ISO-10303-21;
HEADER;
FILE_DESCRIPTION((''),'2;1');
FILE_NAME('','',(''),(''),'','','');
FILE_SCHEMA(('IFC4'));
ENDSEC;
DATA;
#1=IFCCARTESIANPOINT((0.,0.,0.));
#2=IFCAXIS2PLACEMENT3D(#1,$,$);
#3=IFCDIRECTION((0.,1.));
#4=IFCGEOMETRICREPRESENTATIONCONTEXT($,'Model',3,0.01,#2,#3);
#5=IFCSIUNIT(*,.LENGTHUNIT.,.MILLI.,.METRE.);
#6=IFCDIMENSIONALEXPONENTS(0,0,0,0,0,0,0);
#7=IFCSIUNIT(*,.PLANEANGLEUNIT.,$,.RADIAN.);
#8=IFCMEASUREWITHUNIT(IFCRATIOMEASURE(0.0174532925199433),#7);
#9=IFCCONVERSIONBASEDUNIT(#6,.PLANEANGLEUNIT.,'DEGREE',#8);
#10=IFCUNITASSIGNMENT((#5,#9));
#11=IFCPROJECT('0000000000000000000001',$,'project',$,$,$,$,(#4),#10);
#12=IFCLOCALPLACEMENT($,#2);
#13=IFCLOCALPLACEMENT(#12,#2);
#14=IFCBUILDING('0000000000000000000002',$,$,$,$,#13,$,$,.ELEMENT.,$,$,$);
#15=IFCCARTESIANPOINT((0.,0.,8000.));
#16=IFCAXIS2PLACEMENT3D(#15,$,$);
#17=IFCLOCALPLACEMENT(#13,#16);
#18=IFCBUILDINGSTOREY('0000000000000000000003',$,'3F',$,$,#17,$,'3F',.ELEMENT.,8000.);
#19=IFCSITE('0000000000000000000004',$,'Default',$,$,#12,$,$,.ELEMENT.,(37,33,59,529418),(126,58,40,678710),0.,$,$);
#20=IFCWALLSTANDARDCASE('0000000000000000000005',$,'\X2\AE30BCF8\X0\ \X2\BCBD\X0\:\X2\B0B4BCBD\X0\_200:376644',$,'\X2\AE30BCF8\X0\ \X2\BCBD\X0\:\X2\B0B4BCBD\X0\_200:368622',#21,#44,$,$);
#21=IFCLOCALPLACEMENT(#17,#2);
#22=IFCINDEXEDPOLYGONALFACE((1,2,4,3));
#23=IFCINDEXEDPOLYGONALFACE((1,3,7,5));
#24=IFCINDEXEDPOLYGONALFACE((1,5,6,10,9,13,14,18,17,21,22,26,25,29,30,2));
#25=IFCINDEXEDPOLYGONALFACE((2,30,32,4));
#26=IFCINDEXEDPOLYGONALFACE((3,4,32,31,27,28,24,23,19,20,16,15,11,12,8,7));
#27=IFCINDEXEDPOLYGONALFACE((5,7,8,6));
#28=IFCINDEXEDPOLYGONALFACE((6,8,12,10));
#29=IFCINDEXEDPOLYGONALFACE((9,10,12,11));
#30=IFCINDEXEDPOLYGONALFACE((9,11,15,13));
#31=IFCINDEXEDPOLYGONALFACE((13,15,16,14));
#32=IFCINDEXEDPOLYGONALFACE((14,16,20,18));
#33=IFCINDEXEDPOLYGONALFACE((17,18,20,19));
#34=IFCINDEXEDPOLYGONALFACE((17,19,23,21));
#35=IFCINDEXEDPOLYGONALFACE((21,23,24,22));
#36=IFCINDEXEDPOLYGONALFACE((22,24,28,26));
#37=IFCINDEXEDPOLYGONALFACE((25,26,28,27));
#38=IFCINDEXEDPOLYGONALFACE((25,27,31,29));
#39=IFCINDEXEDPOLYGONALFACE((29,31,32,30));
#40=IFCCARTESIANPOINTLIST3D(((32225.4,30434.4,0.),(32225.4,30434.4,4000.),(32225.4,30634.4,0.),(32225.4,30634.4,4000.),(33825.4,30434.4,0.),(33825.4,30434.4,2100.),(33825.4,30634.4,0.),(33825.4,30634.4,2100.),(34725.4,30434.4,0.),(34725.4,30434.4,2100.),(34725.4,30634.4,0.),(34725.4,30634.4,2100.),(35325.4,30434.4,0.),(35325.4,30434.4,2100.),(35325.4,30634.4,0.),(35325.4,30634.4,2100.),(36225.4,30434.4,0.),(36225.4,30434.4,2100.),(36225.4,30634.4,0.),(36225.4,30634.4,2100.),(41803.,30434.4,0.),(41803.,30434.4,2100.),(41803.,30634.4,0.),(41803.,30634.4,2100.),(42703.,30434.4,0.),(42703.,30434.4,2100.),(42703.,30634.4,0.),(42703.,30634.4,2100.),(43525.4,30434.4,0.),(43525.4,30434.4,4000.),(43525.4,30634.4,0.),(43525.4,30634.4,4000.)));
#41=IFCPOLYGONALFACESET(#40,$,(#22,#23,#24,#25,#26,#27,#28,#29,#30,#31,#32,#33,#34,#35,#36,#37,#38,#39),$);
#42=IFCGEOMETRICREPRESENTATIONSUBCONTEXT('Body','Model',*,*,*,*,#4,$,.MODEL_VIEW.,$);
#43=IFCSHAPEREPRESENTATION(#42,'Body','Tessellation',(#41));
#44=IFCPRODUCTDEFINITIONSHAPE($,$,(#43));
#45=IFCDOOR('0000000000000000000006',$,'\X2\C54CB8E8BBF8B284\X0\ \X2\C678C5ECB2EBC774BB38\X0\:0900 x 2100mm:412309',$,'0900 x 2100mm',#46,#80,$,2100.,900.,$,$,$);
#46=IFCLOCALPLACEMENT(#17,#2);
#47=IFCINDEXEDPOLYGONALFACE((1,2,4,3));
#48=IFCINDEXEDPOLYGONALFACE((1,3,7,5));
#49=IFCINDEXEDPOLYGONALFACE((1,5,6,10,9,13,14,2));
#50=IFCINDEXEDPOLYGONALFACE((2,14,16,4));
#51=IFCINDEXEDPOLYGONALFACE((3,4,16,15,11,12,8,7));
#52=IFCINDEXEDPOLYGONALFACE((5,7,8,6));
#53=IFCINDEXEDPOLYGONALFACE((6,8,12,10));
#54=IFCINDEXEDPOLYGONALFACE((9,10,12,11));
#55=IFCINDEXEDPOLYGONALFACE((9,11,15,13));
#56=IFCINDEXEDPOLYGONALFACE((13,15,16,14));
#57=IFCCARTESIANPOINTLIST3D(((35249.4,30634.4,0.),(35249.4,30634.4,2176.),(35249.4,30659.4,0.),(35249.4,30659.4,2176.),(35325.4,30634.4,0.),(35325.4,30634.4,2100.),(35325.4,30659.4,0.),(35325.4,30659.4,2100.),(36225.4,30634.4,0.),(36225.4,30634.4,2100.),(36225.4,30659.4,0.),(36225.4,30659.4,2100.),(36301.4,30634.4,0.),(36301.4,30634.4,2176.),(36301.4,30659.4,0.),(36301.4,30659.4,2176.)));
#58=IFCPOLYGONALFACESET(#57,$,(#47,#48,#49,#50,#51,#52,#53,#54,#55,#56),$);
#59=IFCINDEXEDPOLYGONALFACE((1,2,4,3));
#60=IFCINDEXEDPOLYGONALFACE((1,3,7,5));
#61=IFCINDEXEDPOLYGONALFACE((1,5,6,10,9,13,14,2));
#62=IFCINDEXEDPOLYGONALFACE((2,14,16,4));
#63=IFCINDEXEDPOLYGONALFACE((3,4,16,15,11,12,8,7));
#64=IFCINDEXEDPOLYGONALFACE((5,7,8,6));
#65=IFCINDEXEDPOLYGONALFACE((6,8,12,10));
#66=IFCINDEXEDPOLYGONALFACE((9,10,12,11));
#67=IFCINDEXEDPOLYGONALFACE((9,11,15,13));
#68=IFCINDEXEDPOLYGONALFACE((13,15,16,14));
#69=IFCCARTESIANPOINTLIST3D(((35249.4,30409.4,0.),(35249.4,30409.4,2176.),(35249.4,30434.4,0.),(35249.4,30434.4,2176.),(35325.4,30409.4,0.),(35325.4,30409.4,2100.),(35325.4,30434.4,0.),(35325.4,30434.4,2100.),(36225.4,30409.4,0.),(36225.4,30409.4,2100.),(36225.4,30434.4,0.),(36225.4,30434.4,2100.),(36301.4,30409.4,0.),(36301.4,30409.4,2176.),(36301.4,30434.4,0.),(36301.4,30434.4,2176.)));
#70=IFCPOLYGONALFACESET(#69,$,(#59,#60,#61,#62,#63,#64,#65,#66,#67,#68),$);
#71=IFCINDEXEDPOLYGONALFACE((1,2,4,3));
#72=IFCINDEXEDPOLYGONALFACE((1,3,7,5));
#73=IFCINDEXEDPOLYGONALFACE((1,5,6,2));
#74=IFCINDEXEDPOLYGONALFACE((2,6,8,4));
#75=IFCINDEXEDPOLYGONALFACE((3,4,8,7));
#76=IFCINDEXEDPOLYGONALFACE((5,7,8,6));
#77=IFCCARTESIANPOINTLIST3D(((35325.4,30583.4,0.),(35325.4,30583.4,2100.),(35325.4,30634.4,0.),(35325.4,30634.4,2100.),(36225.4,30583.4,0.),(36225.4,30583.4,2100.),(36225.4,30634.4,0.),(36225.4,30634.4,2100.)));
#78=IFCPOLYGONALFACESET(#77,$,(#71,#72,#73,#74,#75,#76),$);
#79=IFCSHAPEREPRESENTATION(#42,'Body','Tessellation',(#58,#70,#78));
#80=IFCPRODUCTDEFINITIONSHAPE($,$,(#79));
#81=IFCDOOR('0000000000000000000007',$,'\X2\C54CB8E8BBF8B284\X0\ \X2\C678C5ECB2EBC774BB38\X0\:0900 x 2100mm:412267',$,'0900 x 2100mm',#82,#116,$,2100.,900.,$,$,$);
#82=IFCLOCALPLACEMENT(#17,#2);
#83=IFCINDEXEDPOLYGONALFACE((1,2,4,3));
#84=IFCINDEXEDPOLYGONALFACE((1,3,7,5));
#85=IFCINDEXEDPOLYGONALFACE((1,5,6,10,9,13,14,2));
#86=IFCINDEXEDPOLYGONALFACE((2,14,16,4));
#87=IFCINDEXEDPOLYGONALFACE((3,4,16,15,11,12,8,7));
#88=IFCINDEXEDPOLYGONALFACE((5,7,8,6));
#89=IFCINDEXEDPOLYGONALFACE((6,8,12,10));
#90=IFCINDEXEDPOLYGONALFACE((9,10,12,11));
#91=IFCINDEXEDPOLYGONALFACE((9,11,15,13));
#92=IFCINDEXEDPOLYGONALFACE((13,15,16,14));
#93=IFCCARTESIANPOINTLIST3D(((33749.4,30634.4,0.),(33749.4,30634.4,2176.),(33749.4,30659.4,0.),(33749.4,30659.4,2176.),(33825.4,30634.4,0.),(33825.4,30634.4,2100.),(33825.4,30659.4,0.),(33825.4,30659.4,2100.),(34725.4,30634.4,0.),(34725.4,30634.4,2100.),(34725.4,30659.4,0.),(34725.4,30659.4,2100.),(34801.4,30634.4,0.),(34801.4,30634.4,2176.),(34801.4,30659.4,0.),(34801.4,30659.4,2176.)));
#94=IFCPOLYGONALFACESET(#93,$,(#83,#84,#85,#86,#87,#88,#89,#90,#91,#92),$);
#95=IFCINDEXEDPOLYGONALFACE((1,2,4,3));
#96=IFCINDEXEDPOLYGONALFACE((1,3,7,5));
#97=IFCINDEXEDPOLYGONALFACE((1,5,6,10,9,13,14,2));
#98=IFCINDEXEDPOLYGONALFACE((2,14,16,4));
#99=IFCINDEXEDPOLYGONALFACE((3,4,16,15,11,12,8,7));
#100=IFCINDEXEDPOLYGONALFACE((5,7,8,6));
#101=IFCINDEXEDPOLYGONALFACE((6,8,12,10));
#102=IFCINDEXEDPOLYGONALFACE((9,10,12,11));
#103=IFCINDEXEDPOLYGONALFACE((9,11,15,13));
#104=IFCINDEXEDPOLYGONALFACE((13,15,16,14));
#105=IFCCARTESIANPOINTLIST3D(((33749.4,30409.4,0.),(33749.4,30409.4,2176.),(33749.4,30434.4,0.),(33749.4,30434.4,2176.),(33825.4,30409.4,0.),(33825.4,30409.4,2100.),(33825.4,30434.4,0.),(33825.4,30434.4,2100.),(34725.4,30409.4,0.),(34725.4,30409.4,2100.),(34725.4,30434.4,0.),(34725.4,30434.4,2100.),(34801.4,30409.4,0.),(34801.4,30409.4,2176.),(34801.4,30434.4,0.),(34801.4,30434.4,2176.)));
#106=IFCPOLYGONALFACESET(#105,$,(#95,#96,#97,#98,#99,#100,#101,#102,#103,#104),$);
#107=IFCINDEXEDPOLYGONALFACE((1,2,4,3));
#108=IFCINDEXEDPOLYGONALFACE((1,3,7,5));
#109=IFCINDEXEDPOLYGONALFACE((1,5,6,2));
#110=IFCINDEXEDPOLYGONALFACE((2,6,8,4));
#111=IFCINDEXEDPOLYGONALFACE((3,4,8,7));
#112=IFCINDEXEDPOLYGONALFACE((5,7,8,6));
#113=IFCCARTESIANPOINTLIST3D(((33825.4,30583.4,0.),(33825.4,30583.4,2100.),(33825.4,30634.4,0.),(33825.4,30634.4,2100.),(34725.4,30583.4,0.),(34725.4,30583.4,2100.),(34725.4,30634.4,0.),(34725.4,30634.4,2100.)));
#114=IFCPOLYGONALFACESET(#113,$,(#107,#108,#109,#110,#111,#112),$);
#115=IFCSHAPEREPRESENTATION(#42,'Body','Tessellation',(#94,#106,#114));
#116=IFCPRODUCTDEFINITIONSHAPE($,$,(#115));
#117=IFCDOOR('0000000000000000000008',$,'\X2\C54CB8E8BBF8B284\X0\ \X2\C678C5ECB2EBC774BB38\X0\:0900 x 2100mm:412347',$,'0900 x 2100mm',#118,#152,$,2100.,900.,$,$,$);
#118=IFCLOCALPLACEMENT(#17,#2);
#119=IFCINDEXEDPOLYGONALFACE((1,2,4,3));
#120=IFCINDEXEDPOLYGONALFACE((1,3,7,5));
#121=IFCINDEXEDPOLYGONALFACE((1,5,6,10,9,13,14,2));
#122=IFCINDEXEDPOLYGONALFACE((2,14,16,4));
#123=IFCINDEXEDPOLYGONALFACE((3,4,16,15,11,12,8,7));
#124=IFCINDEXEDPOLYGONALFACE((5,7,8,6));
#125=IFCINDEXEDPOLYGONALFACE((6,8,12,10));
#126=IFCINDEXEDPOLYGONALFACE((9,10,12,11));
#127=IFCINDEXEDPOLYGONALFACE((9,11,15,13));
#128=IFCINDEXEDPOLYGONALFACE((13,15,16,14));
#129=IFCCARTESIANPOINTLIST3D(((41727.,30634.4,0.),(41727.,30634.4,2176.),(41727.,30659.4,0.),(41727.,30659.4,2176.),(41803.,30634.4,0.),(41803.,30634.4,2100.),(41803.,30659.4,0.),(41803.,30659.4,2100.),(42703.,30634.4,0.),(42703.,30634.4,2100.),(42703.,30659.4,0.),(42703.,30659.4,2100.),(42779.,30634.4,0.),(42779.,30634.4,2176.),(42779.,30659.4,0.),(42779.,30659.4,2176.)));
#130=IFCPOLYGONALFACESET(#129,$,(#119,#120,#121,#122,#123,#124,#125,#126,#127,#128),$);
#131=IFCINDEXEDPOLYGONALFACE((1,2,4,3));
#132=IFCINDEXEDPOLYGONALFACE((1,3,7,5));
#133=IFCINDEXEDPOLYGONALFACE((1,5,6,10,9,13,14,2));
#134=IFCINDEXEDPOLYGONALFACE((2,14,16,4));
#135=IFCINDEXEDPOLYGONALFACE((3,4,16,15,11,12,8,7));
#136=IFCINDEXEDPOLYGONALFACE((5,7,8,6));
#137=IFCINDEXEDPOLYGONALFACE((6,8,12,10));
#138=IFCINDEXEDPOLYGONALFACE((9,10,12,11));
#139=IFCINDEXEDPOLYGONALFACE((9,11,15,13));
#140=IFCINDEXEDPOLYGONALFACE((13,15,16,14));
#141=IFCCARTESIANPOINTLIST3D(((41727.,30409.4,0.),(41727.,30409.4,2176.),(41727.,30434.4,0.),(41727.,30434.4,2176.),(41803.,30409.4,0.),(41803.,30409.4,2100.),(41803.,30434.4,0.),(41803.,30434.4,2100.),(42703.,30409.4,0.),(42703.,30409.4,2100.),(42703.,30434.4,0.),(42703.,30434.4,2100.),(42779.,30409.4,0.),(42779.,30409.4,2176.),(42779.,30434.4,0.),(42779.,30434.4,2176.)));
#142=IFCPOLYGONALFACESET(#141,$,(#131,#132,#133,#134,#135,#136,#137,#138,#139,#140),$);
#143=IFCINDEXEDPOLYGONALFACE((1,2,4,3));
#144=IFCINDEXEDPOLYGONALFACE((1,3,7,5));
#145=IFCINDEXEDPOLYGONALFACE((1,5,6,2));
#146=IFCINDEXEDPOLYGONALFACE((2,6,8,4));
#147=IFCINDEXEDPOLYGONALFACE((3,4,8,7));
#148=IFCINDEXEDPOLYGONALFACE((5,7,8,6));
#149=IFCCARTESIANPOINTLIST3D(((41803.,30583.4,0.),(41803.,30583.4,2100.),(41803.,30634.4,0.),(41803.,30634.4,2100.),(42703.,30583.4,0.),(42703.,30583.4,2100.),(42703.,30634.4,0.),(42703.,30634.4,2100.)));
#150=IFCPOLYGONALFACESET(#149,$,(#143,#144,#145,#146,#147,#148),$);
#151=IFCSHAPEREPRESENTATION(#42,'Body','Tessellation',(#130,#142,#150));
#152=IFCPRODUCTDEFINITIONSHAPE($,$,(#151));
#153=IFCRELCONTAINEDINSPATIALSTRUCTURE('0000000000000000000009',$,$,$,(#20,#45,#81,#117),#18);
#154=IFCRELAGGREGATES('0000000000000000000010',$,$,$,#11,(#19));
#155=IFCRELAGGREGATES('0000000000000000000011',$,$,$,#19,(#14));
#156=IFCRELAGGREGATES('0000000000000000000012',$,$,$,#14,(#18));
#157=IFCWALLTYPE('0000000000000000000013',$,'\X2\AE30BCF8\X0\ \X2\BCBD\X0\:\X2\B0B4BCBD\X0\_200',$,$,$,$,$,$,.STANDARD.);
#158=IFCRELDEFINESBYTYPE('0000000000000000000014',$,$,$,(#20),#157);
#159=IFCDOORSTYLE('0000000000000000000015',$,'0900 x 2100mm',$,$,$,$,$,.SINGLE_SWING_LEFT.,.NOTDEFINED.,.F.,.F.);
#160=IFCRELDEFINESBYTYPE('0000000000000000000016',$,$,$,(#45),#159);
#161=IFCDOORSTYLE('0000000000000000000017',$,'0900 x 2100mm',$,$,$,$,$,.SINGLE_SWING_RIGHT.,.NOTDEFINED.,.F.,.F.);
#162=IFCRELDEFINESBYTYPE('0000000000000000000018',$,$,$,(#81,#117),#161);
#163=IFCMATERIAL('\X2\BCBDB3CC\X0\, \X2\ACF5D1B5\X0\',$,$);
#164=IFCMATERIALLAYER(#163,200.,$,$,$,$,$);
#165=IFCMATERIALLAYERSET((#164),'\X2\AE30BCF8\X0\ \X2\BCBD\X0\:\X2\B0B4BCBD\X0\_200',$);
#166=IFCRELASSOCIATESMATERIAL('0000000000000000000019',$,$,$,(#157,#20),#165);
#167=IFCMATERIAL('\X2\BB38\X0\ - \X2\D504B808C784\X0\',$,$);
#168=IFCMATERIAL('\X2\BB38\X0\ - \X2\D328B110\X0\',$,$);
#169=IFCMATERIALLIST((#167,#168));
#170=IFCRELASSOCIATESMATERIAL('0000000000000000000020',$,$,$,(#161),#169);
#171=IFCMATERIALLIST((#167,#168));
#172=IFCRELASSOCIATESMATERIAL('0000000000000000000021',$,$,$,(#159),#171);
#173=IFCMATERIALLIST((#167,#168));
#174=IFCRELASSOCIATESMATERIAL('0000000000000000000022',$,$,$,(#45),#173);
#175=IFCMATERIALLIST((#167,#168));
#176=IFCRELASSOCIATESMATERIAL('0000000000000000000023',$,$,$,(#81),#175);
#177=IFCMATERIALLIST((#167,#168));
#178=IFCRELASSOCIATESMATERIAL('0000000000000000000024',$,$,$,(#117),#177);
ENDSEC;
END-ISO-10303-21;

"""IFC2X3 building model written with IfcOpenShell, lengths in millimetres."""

from ifc_helpers import new_model, entity, si_unit, converted_unit, direction, frame, frame_2d, origin, place, context, subcontext, project, spatial, polyline, rectangle, outline, extrude, source, transform, mapped, material, material_list, layer, layer_set, layer_usage, type_object, type_shapes, element, fill, save


model = new_model("IFC2X3")

# Units and contexts
model_context = context("Model", 3, precision=0.01, world=origin(), true_north=direction((0.0, 1.0)))
body_context = subcontext(model_context, "Body", "Model", "MODEL_VIEW")
ifc_project = project(units=[si_unit("LENGTHUNIT", "METRE", prefix="MILLI"), converted_unit("PLANEANGLEUNIT", "DEGREE", entity("IfcRatioMeasure", 0.0174532925199433), si_unit("PLANEANGLEUNIT", "RADIAN"), dimensions=[0, 0, 0, 0, 0, 0, 0])], contexts=[model_context])

# Site, building, storey
site_placement = place(None, origin())
site = spatial("IfcSite", under=ifc_project, at=site_placement, Name="Default", CompositionType="ELEMENT", RefLatitude=(37, 33, 59, 529418), RefLongitude=(126, 58, 40, 678710), RefElevation=0.0)
building_placement = place(site_placement, origin())
building = spatial("IfcBuilding", under=site, at=building_placement, CompositionType="ELEMENT")
storey_placement = place(building_placement, frame((0.0, 0.0, 8000.0)))
storey = spatial("IfcBuildingStorey", under=building, at=storey_placement, Name="3F", LongName="3F", CompositionType="ELEMENT", Elevation=8000.0)

# Shared definitions
ifc_material_1 = material(Name="벽돌, 공통")
ifc_layer_1 = layer(ifc_material_1, 200.0)
ifc_layer_set_1 = layer_set([ifc_layer_1], Name="기본 벽:내벽_200")
wall_type_1 = type_object("IfcWallType", Name="기본 벽:내벽_200", PredefinedType="STANDARD", material=ifc_layer_set_1)
ifc_material_2 = material(Name="문 - 프레임")
ifc_material_3 = material(Name="문 - 패널")
ifc_material_list_1 = material_list([ifc_material_2, ifc_material_3])
door_style_1 = type_object("IfcDoorStyle", Name="0900 x 2100mm", ConstructionType="NOTDEFINED", OperationType="SINGLE_SWING_RIGHT", ParameterTakesPrecedence=False, Sizeable=False, material=ifc_material_list_1)
shared_shape_1 = source(origin(), body_context, "Body", "SweptSolid", [
    extrude(outline(polyline([(-526.0, -1107.0), (526.0, -1107.0), (526.0, 1069.0), (450.0, 1069.0), (450.0, -1031.0), (-450.0, -1031.0), (-450.0, 1069.0), (-526.0, 1069.0), (-526.0, -1107.0)])), frame((450.0, 200.0, 1069.0), z_axis=(0.0, 1.0, 0.0), x_axis=(1.0, 0.0, 0.0)), (0.0, 0.0, 1.0), 25.0),
    extrude(outline(polyline([(-1107.0, -526.0), (1069.0, -526.0), (1069.0, -450.0), (-1031.0, -450.0), (-1031.0, 450.0), (1069.0, 450.0), (1069.0, 526.0), (-1107.0, 526.0), (-1107.0, -526.0)])), frame((450.0, -25.0, 1069.0), z_axis=(0.0, 1.0, 0.0), x_axis=(0.0, 0.0, -1.0)), (0.0, 0.0, 1.0), 25.0),
    extrude(rectangle(XDim=51.0, YDim=900.0, at=frame_2d((0.0, 0.0), x_axis=(1.0, 0.0))), frame((450.0, 174.5, 0.0), z_axis=(0.0, 0.0, 1.0), x_axis=(0.0, 1.0, 0.0)), (0.0, 0.0, 1.0), 2100.0),
])
type_shapes(door_style_1, [shared_shape_1])

# Wall, openings, doors
ifc_layer_usage_1 = layer_usage(ifc_layer_set_1, "AXIS2", "NEGATIVE", 100.0)
wall_1_placement = place(storey_placement, frame((32225.4, 30534.4, 0.0)))
wall_1 = element("IfcWallStandardCase", 1, at=wall_1_placement, inside=storey, type_object=wall_type_1, material=ifc_layer_usage_1, Name="기본 벽:내벽_200:376644", ObjectType="기본 벽:내벽_200:368622", context=body_context, shape_type="SweptSolid", body=[
    extrude(rectangle(XDim=11300.0, YDim=200.0, at=frame_2d((5650.0, 0.0), x_axis=(-1.0, 0.0))), origin(), (0.0, 0.0, 1.0), 4000.0),
])
opening_1_placement = place(wall_1_placement, frame((1600.0, -100.0, 0.0)))
opening_1 = element("IfcOpeningElement", 2, at=opening_1_placement, cuts=wall_1, ObjectType="Opening", context=body_context, shape_type="SweptSolid", body=[
    extrude(rectangle(XDim=900.0, YDim=2100.0, at=frame_2d((1050.0, 450.0), x_axis=(0.0, 1.0))), frame((0.0, 0.0, 0.0), z_axis=(0.0, 1.0, 0.0), x_axis=(0.0, 0.0, 1.0)), (0.0, 0.0, 1.0), 200.0),
])
opening_2_placement = place(wall_1_placement, frame((3100.0, -100.0, 0.0)))
opening_2 = element("IfcOpeningElement", 3, at=opening_2_placement, cuts=wall_1, ObjectType="Opening", context=body_context, shape_type="SweptSolid", body=[
    extrude(rectangle(XDim=900.0, YDim=2100.0, at=frame_2d((1050.0, 450.0), x_axis=(0.0, -1.0))), frame((0.0, 0.0, 0.0), z_axis=(0.0, 1.0, 0.0), x_axis=(0.0, 0.0, 1.0)), (0.0, 0.0, 1.0), 200.0),
])
opening_3_placement = place(wall_1_placement, frame((9577.6, -100.0, 0.0)))
opening_3 = element("IfcOpeningElement", 4, at=opening_3_placement, cuts=wall_1, ObjectType="Opening", context=body_context, shape_type="SweptSolid", body=[
    extrude(rectangle(XDim=900.0, YDim=2100.0, at=frame_2d((1050.0, 450.0), x_axis=(0.0, 1.0))), frame((0.0, 0.0, 0.0), z_axis=(0.0, 1.0, 0.0), x_axis=(0.0, 0.0, 1.0)), (0.0, 0.0, 1.0), 200.0),
])
ifc_material_list_2 = material_list([ifc_material_2, ifc_material_3])
ifc_material_list_3 = material_list([ifc_material_2, ifc_material_3])
door_style_2 = type_object("IfcDoorStyle", Name="0900 x 2100mm", ConstructionType="NOTDEFINED", OperationType="SINGLE_SWING_LEFT", ParameterTakesPrecedence=False, Sizeable=False, material=ifc_material_list_3)
shared_shape_2 = source(origin(), body_context, "Body", "SweptSolid", [
    extrude(outline(polyline([(-526.0, -1107.0), (526.0, -1107.0), (526.0, 1069.0), (450.0, 1069.0), (450.0, -1031.0), (-450.0, -1031.0), (-450.0, 1069.0), (-526.0, 1069.0), (-526.0, -1107.0)])), frame((450.0, 225.0, 1069.0), z_axis=(0.0, -1.0, 0.0), x_axis=(-1.0, 0.0, 0.0)), (0.0, 0.0, 1.0), 25.0),
    extrude(outline(polyline([(-1107.0, -526.0), (1069.0, -526.0), (1069.0, -450.0), (-1031.0, -450.0), (-1031.0, 450.0), (1069.0, 450.0), (1069.0, 526.0), (-1107.0, 526.0), (-1107.0, -526.0)])), frame((450.0, 0.0, 1069.0), z_axis=(0.0, -1.0, 0.0), x_axis=(0.0, 0.0, -1.0)), (0.0, 0.0, 1.0), 25.0),
    extrude(rectangle(XDim=900.0, YDim=51.0, at=frame_2d((0.0, 0.0), x_axis=(1.0, 0.0))), frame((450.0, 174.5, 0.0)), (0.0, 0.0, 1.0), 2100.0),
])
type_shapes(door_style_2, [shared_shape_2])
door_1_placement = place(opening_2_placement, frame((0.0, 0.0, 0.0)))
door_1 = element("IfcDoor", 5, at=door_1_placement, inside=storey, type_object=door_style_2, material=ifc_material_list_2, Name="알루미늄 외여닫이문:0900 x 2100mm:412309", ObjectType="0900 x 2100mm", OverallHeight=2100.0, OverallWidth=900.0, context=body_context, shape_type="MappedRepresentation", body=[
    mapped(shared_shape_2, transform((0.0, 0.0, 0.0), scale=1.0)),
])
fill(opening_2, door_1)
ifc_material_list_4 = material_list([ifc_material_2, ifc_material_3])
door_2_placement = place(opening_1_placement, frame((0.0, 0.0, 0.0)))
door_2 = element("IfcDoor", 6, at=door_2_placement, inside=storey, type_object=door_style_1, material=ifc_material_list_4, Name="알루미늄 외여닫이문:0900 x 2100mm:412267", ObjectType="0900 x 2100mm", OverallHeight=2100.0, OverallWidth=900.0, context=body_context, shape_type="MappedRepresentation", body=[
    mapped(shared_shape_1, transform((0.0, 0.0, 0.0), scale=1.0)),
])
fill(opening_1, door_2)
ifc_material_list_5 = material_list([ifc_material_2, ifc_material_3])
door_3_placement = place(opening_3_placement, frame((0.0, 0.0, 0.0)))
door_3 = element("IfcDoor", 7, at=door_3_placement, inside=storey, type_object=door_style_1, material=ifc_material_list_5, Name="알루미늄 외여닫이문:0900 x 2100mm:412347", ObjectType="0900 x 2100mm", OverallHeight=2100.0, OverallWidth=900.0, context=body_context, shape_type="MappedRepresentation", body=[
    mapped(shared_shape_1, transform((0.0, 0.0, 0.0), scale=1.0)),
])
fill(opening_3, door_3)

save(model, "model.ifc")
